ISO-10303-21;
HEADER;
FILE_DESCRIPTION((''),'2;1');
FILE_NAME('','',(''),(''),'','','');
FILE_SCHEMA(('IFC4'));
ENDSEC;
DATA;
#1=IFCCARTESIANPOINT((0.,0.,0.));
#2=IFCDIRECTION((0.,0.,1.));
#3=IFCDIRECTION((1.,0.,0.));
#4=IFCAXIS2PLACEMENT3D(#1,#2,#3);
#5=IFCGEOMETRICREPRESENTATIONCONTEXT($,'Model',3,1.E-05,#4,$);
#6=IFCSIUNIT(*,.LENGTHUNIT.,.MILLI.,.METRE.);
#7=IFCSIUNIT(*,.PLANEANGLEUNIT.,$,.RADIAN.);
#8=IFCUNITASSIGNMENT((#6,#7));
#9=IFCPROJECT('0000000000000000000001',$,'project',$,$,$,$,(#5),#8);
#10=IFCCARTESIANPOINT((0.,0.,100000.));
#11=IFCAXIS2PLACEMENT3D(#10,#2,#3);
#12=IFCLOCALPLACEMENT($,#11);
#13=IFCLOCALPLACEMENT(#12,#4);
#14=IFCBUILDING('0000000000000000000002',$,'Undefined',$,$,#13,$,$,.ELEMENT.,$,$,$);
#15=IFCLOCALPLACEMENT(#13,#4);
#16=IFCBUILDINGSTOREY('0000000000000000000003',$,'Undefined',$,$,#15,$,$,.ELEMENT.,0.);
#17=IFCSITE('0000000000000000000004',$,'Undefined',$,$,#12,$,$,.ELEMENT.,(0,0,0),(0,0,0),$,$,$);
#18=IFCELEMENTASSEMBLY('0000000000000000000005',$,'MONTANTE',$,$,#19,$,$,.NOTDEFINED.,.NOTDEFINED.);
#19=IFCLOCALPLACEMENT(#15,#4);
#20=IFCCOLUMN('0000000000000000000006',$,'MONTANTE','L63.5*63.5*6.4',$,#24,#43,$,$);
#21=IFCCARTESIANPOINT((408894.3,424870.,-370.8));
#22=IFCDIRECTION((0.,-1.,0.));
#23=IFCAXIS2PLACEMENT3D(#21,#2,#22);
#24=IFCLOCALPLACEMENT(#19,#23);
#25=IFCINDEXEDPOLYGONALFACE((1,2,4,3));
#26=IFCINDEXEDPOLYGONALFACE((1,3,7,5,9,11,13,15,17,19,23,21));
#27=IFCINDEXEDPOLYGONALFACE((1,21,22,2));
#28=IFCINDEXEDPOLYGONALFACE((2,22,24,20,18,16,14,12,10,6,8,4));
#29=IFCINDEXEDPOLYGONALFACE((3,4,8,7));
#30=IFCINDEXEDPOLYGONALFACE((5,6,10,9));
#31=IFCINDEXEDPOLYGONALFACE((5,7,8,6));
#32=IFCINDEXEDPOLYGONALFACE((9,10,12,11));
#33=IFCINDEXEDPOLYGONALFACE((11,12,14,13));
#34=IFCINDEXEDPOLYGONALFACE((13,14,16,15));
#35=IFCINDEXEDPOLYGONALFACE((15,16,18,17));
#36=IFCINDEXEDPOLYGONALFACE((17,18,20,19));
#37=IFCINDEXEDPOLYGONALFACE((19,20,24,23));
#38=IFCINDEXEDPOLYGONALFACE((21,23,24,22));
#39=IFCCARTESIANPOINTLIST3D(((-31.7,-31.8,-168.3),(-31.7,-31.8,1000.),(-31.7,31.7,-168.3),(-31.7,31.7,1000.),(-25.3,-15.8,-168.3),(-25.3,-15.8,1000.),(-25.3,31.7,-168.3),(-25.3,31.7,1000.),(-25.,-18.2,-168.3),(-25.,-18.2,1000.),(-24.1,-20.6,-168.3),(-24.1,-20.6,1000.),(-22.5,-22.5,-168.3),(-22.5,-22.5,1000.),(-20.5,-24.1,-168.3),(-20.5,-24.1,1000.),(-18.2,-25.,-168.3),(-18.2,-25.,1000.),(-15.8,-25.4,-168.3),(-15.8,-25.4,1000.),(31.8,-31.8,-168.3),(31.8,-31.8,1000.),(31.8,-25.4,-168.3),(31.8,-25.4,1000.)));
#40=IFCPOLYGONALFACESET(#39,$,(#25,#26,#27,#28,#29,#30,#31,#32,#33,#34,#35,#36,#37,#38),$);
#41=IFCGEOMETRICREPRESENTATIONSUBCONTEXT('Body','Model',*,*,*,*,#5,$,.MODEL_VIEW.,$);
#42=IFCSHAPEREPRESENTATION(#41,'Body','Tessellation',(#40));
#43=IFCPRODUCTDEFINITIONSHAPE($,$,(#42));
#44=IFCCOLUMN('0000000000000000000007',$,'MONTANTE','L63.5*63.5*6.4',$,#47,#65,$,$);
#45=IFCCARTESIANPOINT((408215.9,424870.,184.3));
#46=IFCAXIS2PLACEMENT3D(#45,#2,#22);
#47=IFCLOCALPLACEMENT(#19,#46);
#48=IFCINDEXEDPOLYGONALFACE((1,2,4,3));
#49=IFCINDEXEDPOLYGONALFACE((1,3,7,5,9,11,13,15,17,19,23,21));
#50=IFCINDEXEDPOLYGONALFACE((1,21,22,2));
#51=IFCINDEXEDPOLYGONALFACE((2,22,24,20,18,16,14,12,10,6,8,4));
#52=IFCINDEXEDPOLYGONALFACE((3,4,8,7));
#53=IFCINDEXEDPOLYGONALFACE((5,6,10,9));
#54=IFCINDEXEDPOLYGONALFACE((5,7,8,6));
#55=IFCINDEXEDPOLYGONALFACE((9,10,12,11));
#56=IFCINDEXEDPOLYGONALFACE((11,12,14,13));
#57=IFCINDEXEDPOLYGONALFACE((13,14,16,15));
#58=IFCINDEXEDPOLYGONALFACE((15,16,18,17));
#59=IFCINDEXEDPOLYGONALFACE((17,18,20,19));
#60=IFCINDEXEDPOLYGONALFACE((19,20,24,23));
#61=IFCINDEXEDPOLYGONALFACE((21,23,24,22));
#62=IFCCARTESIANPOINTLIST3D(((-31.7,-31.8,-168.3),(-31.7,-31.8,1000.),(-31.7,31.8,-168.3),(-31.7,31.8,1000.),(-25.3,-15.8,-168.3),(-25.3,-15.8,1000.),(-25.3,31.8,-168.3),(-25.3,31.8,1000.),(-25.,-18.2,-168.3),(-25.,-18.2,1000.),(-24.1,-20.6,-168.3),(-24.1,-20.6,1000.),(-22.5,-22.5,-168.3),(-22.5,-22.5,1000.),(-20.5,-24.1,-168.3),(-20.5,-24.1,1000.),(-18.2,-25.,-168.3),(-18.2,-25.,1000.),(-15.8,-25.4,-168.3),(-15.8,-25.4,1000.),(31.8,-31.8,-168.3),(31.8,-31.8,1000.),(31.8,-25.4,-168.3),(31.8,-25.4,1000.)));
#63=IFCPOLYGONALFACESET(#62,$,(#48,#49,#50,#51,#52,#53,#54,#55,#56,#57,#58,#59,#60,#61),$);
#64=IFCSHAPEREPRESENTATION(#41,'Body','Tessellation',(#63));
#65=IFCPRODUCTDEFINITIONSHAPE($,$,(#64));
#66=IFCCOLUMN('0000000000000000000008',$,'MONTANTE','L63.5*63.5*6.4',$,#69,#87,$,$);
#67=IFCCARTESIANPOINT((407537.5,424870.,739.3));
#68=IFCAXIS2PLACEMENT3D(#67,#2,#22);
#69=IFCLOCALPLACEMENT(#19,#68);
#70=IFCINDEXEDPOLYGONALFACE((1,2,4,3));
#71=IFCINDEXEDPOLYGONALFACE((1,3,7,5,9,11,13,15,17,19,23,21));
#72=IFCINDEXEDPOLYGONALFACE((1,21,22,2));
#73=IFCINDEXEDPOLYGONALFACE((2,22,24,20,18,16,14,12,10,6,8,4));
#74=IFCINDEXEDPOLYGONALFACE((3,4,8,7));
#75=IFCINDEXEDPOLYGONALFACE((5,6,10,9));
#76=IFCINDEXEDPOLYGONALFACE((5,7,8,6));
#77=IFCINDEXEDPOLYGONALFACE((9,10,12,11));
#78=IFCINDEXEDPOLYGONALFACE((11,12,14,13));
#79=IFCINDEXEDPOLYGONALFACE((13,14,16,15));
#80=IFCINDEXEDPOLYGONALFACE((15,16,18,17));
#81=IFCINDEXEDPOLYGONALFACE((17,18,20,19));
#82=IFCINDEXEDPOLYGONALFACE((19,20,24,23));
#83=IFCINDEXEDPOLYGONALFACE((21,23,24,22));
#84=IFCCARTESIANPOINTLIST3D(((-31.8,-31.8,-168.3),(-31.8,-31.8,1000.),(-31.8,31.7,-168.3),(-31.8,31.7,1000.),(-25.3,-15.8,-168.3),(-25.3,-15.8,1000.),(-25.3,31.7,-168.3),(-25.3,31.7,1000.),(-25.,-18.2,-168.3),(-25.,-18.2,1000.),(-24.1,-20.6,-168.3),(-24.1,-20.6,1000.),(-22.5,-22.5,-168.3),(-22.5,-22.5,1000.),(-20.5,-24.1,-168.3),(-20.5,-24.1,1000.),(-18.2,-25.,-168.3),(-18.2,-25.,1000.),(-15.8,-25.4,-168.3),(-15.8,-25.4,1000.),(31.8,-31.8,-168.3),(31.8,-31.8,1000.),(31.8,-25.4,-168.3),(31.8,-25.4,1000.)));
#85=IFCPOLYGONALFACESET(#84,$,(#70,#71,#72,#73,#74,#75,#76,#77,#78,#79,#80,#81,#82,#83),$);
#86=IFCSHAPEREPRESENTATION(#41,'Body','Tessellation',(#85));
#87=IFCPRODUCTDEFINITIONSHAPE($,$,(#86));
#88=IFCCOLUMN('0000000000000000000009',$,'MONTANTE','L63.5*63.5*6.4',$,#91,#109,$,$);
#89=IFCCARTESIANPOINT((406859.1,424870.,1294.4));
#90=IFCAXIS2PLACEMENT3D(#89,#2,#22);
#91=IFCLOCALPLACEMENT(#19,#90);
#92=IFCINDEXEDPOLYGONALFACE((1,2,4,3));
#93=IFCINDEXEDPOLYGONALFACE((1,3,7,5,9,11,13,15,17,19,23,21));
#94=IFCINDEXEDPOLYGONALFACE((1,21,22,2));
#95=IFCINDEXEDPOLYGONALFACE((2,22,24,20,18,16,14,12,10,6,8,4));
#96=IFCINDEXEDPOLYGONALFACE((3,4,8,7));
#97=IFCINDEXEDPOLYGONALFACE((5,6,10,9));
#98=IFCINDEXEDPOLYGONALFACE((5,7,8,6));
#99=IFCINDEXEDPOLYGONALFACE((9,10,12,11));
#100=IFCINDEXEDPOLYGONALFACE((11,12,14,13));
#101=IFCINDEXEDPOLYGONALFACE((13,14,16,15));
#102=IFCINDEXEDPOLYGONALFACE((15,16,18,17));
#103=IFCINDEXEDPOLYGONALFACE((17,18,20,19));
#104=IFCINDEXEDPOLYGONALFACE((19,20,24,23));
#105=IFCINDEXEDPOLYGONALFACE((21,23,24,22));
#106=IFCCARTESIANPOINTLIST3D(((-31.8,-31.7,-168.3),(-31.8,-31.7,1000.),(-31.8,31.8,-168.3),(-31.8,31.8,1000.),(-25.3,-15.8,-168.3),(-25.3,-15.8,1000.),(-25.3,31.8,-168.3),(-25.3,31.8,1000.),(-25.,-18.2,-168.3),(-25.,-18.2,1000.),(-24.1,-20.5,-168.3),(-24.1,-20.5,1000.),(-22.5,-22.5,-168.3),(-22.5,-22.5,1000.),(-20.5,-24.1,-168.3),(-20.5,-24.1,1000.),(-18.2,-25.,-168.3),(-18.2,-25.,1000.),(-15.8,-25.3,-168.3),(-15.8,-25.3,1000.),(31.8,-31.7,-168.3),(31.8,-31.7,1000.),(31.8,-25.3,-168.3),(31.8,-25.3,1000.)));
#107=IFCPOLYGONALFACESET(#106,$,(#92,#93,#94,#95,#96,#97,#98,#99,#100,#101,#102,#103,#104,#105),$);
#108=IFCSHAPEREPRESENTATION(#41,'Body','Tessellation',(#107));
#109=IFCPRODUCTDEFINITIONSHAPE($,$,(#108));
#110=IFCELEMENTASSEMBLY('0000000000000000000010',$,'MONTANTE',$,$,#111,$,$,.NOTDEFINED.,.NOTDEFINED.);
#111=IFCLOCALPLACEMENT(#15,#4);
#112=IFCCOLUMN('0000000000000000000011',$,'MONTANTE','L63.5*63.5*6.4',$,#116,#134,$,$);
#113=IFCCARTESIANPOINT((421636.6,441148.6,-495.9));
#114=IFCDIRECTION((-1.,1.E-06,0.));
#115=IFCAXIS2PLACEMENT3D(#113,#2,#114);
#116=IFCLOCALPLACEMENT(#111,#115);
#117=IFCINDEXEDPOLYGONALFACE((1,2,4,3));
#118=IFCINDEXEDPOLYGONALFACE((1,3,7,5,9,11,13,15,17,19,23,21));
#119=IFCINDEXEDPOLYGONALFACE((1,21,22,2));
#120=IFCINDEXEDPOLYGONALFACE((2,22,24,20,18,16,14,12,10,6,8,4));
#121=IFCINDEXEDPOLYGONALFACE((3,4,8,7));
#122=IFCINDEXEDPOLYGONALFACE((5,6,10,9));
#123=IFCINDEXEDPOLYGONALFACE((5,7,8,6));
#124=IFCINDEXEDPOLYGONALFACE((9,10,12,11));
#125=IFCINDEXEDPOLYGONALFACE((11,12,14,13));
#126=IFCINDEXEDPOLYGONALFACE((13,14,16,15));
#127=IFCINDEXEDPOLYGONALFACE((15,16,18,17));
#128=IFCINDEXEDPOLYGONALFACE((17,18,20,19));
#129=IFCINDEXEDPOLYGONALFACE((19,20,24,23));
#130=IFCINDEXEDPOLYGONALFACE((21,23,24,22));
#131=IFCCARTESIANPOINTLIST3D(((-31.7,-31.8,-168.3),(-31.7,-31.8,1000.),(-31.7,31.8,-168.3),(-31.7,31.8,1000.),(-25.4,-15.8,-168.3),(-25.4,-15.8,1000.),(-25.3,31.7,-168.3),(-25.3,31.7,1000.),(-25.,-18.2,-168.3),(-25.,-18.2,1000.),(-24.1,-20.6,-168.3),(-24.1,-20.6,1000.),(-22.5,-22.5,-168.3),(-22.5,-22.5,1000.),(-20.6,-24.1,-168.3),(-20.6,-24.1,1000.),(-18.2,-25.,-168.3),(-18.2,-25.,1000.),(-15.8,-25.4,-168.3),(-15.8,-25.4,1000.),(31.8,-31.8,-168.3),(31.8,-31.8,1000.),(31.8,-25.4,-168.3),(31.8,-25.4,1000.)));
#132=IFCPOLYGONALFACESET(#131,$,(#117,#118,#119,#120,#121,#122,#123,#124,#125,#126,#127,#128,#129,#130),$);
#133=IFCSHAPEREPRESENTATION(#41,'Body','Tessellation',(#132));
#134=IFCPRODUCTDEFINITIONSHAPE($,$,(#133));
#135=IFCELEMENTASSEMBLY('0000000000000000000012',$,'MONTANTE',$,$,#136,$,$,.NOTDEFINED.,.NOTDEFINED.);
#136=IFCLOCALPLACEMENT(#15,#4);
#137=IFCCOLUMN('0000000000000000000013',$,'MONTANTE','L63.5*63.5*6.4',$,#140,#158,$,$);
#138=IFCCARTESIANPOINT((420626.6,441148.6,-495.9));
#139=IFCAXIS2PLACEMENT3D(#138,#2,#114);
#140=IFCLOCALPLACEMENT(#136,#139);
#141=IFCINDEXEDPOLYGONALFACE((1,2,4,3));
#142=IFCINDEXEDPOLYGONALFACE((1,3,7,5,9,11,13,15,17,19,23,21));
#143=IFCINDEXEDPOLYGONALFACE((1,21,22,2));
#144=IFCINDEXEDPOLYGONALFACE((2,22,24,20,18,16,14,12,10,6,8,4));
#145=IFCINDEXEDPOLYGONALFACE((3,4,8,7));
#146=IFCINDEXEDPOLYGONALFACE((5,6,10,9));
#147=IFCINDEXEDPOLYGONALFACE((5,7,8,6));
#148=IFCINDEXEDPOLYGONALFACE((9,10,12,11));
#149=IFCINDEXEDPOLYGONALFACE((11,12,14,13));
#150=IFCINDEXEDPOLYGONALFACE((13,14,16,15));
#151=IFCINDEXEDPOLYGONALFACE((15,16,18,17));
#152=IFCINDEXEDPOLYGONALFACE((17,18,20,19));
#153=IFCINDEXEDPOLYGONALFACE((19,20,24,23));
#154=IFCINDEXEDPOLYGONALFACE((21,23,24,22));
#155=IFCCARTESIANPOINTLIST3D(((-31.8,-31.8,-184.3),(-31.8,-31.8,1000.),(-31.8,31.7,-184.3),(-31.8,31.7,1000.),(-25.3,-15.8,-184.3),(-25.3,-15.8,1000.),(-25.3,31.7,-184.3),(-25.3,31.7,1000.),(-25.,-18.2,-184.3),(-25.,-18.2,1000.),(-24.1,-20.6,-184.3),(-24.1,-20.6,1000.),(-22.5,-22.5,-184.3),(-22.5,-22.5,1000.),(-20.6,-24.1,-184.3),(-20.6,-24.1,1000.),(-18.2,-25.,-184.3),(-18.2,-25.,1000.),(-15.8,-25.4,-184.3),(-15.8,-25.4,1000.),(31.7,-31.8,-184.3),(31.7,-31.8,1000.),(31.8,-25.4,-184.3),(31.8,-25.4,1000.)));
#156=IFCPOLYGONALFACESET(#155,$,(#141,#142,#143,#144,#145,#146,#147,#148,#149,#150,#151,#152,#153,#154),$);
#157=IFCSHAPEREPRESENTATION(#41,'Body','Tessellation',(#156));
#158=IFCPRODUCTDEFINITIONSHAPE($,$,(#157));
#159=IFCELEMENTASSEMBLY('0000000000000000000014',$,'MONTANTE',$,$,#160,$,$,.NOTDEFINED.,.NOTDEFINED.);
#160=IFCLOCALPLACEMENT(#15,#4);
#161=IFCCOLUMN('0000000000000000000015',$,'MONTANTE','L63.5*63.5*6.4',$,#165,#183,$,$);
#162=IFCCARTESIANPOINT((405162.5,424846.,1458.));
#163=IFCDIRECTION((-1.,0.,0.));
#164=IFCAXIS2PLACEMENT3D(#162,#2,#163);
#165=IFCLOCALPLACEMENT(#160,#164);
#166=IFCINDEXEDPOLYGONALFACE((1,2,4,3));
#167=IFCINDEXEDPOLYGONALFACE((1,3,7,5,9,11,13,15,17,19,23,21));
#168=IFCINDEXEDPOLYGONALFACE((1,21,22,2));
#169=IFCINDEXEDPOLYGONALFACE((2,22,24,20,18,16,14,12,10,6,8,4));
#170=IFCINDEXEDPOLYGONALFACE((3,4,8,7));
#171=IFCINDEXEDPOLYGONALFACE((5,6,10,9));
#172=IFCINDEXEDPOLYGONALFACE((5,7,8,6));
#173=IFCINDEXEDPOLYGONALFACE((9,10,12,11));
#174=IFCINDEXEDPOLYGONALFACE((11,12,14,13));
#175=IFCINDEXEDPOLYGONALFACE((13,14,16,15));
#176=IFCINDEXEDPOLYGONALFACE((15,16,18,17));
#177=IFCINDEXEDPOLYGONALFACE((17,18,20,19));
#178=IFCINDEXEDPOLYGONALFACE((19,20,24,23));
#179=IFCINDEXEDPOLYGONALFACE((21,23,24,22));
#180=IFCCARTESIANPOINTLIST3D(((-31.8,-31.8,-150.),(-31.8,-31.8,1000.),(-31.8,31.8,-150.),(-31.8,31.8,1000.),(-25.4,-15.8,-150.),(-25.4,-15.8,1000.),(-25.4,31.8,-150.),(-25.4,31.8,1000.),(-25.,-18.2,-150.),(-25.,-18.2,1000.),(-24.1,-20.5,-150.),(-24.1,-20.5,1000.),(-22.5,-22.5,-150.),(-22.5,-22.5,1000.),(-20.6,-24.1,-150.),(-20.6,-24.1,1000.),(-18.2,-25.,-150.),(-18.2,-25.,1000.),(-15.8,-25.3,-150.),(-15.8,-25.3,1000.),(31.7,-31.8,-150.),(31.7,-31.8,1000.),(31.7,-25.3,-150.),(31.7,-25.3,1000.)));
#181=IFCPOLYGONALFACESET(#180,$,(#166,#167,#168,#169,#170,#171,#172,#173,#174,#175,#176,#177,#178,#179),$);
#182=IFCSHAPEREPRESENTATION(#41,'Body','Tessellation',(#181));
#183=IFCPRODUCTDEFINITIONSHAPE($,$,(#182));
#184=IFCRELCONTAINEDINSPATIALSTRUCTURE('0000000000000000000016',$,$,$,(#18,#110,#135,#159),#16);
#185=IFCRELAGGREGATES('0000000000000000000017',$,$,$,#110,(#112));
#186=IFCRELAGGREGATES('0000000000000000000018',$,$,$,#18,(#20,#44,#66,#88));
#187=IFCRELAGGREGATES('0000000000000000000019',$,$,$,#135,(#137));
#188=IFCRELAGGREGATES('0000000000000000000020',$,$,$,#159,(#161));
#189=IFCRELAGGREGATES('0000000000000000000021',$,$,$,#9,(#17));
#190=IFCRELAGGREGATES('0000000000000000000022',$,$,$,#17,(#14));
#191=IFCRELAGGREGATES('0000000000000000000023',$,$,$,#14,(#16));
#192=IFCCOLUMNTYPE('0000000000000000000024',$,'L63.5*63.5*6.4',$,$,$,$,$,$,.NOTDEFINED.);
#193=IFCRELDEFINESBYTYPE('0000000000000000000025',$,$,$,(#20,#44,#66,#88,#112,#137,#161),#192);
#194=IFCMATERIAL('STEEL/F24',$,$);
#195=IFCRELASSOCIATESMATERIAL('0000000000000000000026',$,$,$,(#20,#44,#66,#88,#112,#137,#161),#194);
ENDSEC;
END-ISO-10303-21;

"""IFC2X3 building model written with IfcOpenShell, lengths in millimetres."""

from ifc_helpers import new_model, si_unit, frame, origin_with_axes, origin_2d_with_axis, place, context, subcontext, project, spatial, l_section, extrude, clip, halfspace, material, type_object, element, aggregate, save


model = new_model("IFC2X3")

# Units and contexts
model_context = context("Model", 3, precision=1e-05, world=origin_with_axes())
body_context = subcontext(model_context, "Body", "Model", "MODEL_VIEW")
ifc_project = project(units=[si_unit("LENGTHUNIT", "METRE", prefix="MILLI"), si_unit("PLANEANGLEUNIT", "RADIAN")], contexts=[model_context])

# Site, building, storey
site_placement = place(None, frame((0.0, 0.0, 100000.0), z_axis=(0.0, 0.0, 1.0), x_axis=(1.0, 0.0, 0.0)))
site = spatial("IfcSite", under=ifc_project, at=site_placement, Name="Undefined", CompositionType="ELEMENT", RefLatitude=(0, 0, 0), RefLongitude=(0, 0, 0))
building_placement = place(site_placement, origin_with_axes())
building = spatial("IfcBuilding", under=site, at=building_placement, Name="Undefined", CompositionType="ELEMENT")
storey_placement = place(building_placement, origin_with_axes())
storey = spatial("IfcBuildingStorey", under=building, at=storey_placement, Name="Undefined", CompositionType="ELEMENT", Elevation=0.0)

# Element assembly, columns
assembly_1_placement = place(storey_placement, origin_with_axes())
assembly_1 = element("IfcElementAssembly", 1, at=assembly_1_placement, inside=storey, Name="MONTANTE", AssemblyPlace="NOTDEFINED", PredefinedType="NOTDEFINED")
ifc_material_1 = material(Name="STEEL/F24")
column_type_1 = type_object("IfcColumnType", Name="L63.5*63.5*6.4", PredefinedType="NOTDEFINED")
column_1_placement = place(assembly_1_placement, frame((408894.3, 424870.0, -370.8), z_axis=(0.0, 0.0, 1.0), x_axis=(0.0, -1.0, 0.0)))
column_1 = element("IfcColumn", 2, at=column_1_placement, type_object=column_type_1, material=ifc_material_1, Name="MONTANTE", Description="L63.5*63.5*6.4", context=body_context, shape_type="Clipping", body=[
    clip(extrude(l_section(Depth=63.5, Width=63.5, Thickness=6.4, FilletRadius=9.6, at=origin_2d_with_axis()), frame((0.0, 0.0, 1000.0), z_axis=(0.0, 0.0, -1.0), x_axis=(0.0, 1.0, 0.0)), (0.0, 0.0, 1.0), 1168.3), halfspace(frame((0.0, 0.0, -168.3), z_axis=(0.0, 0.0, -1.0), x_axis=(0.0, -1.0, 0.0)), False)),
])
column_2_placement = place(assembly_1_placement, frame((408215.9, 424870.0, 184.3), z_axis=(0.0, 0.0, 1.0), x_axis=(0.0, -1.0, 0.0)))
column_2 = element("IfcColumn", 3, at=column_2_placement, type_object=column_type_1, material=ifc_material_1, Name="MONTANTE", Description="L63.5*63.5*6.4", context=body_context, shape_type="Clipping", body=[
    clip(extrude(l_section(Depth=63.5, Width=63.5, Thickness=6.4, FilletRadius=9.6, at=origin_2d_with_axis()), frame((0.0, 0.0, 1000.0), z_axis=(0.0, 0.0, -1.0), x_axis=(0.0, 1.0, 0.0)), (0.0, 0.0, 1.0), 1168.3), halfspace(frame((0.0, 0.0, -168.3), z_axis=(0.0, 0.0, -1.0), x_axis=(0.0, -1.0, 0.0)), False)),
])
column_3_placement = place(assembly_1_placement, frame((407537.5, 424870.0, 739.3), z_axis=(0.0, 0.0, 1.0), x_axis=(0.0, -1.0, 0.0)))
column_3 = element("IfcColumn", 4, at=column_3_placement, type_object=column_type_1, material=ifc_material_1, Name="MONTANTE", Description="L63.5*63.5*6.4", context=body_context, shape_type="Clipping", body=[
    clip(extrude(l_section(Depth=63.5, Width=63.5, Thickness=6.4, FilletRadius=9.6, at=origin_2d_with_axis()), frame((0.0, 0.0, 1000.0), z_axis=(0.0, 0.0, -1.0), x_axis=(0.0, 1.0, 0.0)), (0.0, 0.0, 1.0), 1168.3), halfspace(frame((0.0, 0.0, -168.3), z_axis=(0.0, 0.0, -1.0), x_axis=(0.0, -1.0, 0.0)), False)),
])
column_4_placement = place(assembly_1_placement, frame((406859.1, 424870.0, 1294.4), z_axis=(0.0, 0.0, 1.0), x_axis=(0.0, -1.0, 0.0)))
column_4 = element("IfcColumn", 5, at=column_4_placement, type_object=column_type_1, material=ifc_material_1, Name="MONTANTE", Description="L63.5*63.5*6.4", context=body_context, shape_type="Clipping", body=[
    clip(extrude(l_section(Depth=63.5, Width=63.5, Thickness=6.4, FilletRadius=9.6, at=origin_2d_with_axis()), frame((0.0, 0.0, 1000.0), z_axis=(0.0, 0.0, -1.0), x_axis=(0.0, 1.0, 0.0)), (0.0, 0.0, 1.0), 1168.3), halfspace(frame((0.0, 0.0, -168.3), z_axis=(0.0, 0.0, -1.0), x_axis=(0.0, -1.0, 0.0)), False)),
])

# Element assemblies, columns
assembly_2_placement = place(storey_placement, origin_with_axes())
assembly_2 = element("IfcElementAssembly", 6, at=assembly_2_placement, inside=storey, Name="MONTANTE", AssemblyPlace="NOTDEFINED", PredefinedType="NOTDEFINED")
column_5_placement = place(assembly_2_placement, frame((421636.6, 441148.6, -495.9), z_axis=(0.0, 0.0, 1.0), x_axis=(-1.0, 0.000001, 0.0)))
column_5 = element("IfcColumn", 7, at=column_5_placement, type_object=column_type_1, material=ifc_material_1, Name="MONTANTE", Description="L63.5*63.5*6.4", context=body_context, shape_type="Clipping", body=[
    clip(extrude(l_section(Depth=63.5, Width=63.5, Thickness=6.4, FilletRadius=9.6, at=origin_2d_with_axis()), frame((0.0, 0.0, 1000.0), z_axis=(0.0, 0.0, -1.0), x_axis=(0.0, 1.0, 0.0)), (0.0, 0.0, 1.0), 1168.3), halfspace(frame((0.0, 0.0, -168.3), z_axis=(0.0, 0.0, -1.0), x_axis=(0.0, -1.0, 0.0)), False)),
])
aggregate(assembly_2, [column_5])
assembly_3_placement = place(storey_placement, origin_with_axes())
assembly_3 = element("IfcElementAssembly", 8, at=assembly_3_placement, inside=storey, Name="MONTANTE", AssemblyPlace="NOTDEFINED", PredefinedType="NOTDEFINED")
column_6_placement = place(assembly_3_placement, frame((420626.6, 441148.6, -495.9), z_axis=(0.0, 0.0, 1.0), x_axis=(-1.0, 0.000001, 0.0)))
column_6 = element("IfcColumn", 9, at=column_6_placement, type_object=column_type_1, material=ifc_material_1, Name="MONTANTE", Description="L63.5*63.5*6.4", context=body_context, shape_type="Clipping", body=[
    clip(extrude(l_section(Depth=63.5, Width=63.5, Thickness=6.4, FilletRadius=9.6, at=origin_2d_with_axis()), frame((0.0, 0.0, 1000.0), z_axis=(0.0, 0.0, -1.0), x_axis=(0.0, 1.0, 0.0)), (0.0, 0.0, 1.0), 1184.3), halfspace(frame((0.0, 0.0, -184.3), z_axis=(0.0, 0.0, -1.0), x_axis=(0.0, 1.0, 0.0)), False)),
])
assembly_4_placement = place(storey_placement, origin_with_axes())
assembly_4 = element("IfcElementAssembly", 10, at=assembly_4_placement, inside=storey, Name="MONTANTE", AssemblyPlace="NOTDEFINED", PredefinedType="NOTDEFINED")
column_7_placement = place(assembly_4_placement, frame((405162.5, 424846.0, 1458.0), z_axis=(0.0, 0.0, 1.0), x_axis=(-1.0, 0.0, 0.0)))
column_7 = element("IfcColumn", 11, at=column_7_placement, type_object=column_type_1, material=ifc_material_1, Name="MONTANTE", Description="L63.5*63.5*6.4", context=body_context, shape_type="Clipping", body=[
    clip(extrude(l_section(Depth=63.5, Width=63.5, Thickness=6.4, FilletRadius=9.6, at=origin_2d_with_axis()), frame((0.0, 0.0, 1000.0), z_axis=(0.0, 0.0, -1.0), x_axis=(0.0, 1.0, 0.0)), (0.0, 0.0, 1.0), 1150.0), halfspace(frame((0.0, 0.0, -150.0), z_axis=(0.0, 0.0, -1.0), x_axis=(0.0, 1.0, 0.0)), False)),
])

aggregate(assembly_1, [column_1, column_2, column_3, column_4])

aggregate(assembly_3, [column_6])
aggregate(assembly_4, [column_7])

save(model, "model.ifc")
